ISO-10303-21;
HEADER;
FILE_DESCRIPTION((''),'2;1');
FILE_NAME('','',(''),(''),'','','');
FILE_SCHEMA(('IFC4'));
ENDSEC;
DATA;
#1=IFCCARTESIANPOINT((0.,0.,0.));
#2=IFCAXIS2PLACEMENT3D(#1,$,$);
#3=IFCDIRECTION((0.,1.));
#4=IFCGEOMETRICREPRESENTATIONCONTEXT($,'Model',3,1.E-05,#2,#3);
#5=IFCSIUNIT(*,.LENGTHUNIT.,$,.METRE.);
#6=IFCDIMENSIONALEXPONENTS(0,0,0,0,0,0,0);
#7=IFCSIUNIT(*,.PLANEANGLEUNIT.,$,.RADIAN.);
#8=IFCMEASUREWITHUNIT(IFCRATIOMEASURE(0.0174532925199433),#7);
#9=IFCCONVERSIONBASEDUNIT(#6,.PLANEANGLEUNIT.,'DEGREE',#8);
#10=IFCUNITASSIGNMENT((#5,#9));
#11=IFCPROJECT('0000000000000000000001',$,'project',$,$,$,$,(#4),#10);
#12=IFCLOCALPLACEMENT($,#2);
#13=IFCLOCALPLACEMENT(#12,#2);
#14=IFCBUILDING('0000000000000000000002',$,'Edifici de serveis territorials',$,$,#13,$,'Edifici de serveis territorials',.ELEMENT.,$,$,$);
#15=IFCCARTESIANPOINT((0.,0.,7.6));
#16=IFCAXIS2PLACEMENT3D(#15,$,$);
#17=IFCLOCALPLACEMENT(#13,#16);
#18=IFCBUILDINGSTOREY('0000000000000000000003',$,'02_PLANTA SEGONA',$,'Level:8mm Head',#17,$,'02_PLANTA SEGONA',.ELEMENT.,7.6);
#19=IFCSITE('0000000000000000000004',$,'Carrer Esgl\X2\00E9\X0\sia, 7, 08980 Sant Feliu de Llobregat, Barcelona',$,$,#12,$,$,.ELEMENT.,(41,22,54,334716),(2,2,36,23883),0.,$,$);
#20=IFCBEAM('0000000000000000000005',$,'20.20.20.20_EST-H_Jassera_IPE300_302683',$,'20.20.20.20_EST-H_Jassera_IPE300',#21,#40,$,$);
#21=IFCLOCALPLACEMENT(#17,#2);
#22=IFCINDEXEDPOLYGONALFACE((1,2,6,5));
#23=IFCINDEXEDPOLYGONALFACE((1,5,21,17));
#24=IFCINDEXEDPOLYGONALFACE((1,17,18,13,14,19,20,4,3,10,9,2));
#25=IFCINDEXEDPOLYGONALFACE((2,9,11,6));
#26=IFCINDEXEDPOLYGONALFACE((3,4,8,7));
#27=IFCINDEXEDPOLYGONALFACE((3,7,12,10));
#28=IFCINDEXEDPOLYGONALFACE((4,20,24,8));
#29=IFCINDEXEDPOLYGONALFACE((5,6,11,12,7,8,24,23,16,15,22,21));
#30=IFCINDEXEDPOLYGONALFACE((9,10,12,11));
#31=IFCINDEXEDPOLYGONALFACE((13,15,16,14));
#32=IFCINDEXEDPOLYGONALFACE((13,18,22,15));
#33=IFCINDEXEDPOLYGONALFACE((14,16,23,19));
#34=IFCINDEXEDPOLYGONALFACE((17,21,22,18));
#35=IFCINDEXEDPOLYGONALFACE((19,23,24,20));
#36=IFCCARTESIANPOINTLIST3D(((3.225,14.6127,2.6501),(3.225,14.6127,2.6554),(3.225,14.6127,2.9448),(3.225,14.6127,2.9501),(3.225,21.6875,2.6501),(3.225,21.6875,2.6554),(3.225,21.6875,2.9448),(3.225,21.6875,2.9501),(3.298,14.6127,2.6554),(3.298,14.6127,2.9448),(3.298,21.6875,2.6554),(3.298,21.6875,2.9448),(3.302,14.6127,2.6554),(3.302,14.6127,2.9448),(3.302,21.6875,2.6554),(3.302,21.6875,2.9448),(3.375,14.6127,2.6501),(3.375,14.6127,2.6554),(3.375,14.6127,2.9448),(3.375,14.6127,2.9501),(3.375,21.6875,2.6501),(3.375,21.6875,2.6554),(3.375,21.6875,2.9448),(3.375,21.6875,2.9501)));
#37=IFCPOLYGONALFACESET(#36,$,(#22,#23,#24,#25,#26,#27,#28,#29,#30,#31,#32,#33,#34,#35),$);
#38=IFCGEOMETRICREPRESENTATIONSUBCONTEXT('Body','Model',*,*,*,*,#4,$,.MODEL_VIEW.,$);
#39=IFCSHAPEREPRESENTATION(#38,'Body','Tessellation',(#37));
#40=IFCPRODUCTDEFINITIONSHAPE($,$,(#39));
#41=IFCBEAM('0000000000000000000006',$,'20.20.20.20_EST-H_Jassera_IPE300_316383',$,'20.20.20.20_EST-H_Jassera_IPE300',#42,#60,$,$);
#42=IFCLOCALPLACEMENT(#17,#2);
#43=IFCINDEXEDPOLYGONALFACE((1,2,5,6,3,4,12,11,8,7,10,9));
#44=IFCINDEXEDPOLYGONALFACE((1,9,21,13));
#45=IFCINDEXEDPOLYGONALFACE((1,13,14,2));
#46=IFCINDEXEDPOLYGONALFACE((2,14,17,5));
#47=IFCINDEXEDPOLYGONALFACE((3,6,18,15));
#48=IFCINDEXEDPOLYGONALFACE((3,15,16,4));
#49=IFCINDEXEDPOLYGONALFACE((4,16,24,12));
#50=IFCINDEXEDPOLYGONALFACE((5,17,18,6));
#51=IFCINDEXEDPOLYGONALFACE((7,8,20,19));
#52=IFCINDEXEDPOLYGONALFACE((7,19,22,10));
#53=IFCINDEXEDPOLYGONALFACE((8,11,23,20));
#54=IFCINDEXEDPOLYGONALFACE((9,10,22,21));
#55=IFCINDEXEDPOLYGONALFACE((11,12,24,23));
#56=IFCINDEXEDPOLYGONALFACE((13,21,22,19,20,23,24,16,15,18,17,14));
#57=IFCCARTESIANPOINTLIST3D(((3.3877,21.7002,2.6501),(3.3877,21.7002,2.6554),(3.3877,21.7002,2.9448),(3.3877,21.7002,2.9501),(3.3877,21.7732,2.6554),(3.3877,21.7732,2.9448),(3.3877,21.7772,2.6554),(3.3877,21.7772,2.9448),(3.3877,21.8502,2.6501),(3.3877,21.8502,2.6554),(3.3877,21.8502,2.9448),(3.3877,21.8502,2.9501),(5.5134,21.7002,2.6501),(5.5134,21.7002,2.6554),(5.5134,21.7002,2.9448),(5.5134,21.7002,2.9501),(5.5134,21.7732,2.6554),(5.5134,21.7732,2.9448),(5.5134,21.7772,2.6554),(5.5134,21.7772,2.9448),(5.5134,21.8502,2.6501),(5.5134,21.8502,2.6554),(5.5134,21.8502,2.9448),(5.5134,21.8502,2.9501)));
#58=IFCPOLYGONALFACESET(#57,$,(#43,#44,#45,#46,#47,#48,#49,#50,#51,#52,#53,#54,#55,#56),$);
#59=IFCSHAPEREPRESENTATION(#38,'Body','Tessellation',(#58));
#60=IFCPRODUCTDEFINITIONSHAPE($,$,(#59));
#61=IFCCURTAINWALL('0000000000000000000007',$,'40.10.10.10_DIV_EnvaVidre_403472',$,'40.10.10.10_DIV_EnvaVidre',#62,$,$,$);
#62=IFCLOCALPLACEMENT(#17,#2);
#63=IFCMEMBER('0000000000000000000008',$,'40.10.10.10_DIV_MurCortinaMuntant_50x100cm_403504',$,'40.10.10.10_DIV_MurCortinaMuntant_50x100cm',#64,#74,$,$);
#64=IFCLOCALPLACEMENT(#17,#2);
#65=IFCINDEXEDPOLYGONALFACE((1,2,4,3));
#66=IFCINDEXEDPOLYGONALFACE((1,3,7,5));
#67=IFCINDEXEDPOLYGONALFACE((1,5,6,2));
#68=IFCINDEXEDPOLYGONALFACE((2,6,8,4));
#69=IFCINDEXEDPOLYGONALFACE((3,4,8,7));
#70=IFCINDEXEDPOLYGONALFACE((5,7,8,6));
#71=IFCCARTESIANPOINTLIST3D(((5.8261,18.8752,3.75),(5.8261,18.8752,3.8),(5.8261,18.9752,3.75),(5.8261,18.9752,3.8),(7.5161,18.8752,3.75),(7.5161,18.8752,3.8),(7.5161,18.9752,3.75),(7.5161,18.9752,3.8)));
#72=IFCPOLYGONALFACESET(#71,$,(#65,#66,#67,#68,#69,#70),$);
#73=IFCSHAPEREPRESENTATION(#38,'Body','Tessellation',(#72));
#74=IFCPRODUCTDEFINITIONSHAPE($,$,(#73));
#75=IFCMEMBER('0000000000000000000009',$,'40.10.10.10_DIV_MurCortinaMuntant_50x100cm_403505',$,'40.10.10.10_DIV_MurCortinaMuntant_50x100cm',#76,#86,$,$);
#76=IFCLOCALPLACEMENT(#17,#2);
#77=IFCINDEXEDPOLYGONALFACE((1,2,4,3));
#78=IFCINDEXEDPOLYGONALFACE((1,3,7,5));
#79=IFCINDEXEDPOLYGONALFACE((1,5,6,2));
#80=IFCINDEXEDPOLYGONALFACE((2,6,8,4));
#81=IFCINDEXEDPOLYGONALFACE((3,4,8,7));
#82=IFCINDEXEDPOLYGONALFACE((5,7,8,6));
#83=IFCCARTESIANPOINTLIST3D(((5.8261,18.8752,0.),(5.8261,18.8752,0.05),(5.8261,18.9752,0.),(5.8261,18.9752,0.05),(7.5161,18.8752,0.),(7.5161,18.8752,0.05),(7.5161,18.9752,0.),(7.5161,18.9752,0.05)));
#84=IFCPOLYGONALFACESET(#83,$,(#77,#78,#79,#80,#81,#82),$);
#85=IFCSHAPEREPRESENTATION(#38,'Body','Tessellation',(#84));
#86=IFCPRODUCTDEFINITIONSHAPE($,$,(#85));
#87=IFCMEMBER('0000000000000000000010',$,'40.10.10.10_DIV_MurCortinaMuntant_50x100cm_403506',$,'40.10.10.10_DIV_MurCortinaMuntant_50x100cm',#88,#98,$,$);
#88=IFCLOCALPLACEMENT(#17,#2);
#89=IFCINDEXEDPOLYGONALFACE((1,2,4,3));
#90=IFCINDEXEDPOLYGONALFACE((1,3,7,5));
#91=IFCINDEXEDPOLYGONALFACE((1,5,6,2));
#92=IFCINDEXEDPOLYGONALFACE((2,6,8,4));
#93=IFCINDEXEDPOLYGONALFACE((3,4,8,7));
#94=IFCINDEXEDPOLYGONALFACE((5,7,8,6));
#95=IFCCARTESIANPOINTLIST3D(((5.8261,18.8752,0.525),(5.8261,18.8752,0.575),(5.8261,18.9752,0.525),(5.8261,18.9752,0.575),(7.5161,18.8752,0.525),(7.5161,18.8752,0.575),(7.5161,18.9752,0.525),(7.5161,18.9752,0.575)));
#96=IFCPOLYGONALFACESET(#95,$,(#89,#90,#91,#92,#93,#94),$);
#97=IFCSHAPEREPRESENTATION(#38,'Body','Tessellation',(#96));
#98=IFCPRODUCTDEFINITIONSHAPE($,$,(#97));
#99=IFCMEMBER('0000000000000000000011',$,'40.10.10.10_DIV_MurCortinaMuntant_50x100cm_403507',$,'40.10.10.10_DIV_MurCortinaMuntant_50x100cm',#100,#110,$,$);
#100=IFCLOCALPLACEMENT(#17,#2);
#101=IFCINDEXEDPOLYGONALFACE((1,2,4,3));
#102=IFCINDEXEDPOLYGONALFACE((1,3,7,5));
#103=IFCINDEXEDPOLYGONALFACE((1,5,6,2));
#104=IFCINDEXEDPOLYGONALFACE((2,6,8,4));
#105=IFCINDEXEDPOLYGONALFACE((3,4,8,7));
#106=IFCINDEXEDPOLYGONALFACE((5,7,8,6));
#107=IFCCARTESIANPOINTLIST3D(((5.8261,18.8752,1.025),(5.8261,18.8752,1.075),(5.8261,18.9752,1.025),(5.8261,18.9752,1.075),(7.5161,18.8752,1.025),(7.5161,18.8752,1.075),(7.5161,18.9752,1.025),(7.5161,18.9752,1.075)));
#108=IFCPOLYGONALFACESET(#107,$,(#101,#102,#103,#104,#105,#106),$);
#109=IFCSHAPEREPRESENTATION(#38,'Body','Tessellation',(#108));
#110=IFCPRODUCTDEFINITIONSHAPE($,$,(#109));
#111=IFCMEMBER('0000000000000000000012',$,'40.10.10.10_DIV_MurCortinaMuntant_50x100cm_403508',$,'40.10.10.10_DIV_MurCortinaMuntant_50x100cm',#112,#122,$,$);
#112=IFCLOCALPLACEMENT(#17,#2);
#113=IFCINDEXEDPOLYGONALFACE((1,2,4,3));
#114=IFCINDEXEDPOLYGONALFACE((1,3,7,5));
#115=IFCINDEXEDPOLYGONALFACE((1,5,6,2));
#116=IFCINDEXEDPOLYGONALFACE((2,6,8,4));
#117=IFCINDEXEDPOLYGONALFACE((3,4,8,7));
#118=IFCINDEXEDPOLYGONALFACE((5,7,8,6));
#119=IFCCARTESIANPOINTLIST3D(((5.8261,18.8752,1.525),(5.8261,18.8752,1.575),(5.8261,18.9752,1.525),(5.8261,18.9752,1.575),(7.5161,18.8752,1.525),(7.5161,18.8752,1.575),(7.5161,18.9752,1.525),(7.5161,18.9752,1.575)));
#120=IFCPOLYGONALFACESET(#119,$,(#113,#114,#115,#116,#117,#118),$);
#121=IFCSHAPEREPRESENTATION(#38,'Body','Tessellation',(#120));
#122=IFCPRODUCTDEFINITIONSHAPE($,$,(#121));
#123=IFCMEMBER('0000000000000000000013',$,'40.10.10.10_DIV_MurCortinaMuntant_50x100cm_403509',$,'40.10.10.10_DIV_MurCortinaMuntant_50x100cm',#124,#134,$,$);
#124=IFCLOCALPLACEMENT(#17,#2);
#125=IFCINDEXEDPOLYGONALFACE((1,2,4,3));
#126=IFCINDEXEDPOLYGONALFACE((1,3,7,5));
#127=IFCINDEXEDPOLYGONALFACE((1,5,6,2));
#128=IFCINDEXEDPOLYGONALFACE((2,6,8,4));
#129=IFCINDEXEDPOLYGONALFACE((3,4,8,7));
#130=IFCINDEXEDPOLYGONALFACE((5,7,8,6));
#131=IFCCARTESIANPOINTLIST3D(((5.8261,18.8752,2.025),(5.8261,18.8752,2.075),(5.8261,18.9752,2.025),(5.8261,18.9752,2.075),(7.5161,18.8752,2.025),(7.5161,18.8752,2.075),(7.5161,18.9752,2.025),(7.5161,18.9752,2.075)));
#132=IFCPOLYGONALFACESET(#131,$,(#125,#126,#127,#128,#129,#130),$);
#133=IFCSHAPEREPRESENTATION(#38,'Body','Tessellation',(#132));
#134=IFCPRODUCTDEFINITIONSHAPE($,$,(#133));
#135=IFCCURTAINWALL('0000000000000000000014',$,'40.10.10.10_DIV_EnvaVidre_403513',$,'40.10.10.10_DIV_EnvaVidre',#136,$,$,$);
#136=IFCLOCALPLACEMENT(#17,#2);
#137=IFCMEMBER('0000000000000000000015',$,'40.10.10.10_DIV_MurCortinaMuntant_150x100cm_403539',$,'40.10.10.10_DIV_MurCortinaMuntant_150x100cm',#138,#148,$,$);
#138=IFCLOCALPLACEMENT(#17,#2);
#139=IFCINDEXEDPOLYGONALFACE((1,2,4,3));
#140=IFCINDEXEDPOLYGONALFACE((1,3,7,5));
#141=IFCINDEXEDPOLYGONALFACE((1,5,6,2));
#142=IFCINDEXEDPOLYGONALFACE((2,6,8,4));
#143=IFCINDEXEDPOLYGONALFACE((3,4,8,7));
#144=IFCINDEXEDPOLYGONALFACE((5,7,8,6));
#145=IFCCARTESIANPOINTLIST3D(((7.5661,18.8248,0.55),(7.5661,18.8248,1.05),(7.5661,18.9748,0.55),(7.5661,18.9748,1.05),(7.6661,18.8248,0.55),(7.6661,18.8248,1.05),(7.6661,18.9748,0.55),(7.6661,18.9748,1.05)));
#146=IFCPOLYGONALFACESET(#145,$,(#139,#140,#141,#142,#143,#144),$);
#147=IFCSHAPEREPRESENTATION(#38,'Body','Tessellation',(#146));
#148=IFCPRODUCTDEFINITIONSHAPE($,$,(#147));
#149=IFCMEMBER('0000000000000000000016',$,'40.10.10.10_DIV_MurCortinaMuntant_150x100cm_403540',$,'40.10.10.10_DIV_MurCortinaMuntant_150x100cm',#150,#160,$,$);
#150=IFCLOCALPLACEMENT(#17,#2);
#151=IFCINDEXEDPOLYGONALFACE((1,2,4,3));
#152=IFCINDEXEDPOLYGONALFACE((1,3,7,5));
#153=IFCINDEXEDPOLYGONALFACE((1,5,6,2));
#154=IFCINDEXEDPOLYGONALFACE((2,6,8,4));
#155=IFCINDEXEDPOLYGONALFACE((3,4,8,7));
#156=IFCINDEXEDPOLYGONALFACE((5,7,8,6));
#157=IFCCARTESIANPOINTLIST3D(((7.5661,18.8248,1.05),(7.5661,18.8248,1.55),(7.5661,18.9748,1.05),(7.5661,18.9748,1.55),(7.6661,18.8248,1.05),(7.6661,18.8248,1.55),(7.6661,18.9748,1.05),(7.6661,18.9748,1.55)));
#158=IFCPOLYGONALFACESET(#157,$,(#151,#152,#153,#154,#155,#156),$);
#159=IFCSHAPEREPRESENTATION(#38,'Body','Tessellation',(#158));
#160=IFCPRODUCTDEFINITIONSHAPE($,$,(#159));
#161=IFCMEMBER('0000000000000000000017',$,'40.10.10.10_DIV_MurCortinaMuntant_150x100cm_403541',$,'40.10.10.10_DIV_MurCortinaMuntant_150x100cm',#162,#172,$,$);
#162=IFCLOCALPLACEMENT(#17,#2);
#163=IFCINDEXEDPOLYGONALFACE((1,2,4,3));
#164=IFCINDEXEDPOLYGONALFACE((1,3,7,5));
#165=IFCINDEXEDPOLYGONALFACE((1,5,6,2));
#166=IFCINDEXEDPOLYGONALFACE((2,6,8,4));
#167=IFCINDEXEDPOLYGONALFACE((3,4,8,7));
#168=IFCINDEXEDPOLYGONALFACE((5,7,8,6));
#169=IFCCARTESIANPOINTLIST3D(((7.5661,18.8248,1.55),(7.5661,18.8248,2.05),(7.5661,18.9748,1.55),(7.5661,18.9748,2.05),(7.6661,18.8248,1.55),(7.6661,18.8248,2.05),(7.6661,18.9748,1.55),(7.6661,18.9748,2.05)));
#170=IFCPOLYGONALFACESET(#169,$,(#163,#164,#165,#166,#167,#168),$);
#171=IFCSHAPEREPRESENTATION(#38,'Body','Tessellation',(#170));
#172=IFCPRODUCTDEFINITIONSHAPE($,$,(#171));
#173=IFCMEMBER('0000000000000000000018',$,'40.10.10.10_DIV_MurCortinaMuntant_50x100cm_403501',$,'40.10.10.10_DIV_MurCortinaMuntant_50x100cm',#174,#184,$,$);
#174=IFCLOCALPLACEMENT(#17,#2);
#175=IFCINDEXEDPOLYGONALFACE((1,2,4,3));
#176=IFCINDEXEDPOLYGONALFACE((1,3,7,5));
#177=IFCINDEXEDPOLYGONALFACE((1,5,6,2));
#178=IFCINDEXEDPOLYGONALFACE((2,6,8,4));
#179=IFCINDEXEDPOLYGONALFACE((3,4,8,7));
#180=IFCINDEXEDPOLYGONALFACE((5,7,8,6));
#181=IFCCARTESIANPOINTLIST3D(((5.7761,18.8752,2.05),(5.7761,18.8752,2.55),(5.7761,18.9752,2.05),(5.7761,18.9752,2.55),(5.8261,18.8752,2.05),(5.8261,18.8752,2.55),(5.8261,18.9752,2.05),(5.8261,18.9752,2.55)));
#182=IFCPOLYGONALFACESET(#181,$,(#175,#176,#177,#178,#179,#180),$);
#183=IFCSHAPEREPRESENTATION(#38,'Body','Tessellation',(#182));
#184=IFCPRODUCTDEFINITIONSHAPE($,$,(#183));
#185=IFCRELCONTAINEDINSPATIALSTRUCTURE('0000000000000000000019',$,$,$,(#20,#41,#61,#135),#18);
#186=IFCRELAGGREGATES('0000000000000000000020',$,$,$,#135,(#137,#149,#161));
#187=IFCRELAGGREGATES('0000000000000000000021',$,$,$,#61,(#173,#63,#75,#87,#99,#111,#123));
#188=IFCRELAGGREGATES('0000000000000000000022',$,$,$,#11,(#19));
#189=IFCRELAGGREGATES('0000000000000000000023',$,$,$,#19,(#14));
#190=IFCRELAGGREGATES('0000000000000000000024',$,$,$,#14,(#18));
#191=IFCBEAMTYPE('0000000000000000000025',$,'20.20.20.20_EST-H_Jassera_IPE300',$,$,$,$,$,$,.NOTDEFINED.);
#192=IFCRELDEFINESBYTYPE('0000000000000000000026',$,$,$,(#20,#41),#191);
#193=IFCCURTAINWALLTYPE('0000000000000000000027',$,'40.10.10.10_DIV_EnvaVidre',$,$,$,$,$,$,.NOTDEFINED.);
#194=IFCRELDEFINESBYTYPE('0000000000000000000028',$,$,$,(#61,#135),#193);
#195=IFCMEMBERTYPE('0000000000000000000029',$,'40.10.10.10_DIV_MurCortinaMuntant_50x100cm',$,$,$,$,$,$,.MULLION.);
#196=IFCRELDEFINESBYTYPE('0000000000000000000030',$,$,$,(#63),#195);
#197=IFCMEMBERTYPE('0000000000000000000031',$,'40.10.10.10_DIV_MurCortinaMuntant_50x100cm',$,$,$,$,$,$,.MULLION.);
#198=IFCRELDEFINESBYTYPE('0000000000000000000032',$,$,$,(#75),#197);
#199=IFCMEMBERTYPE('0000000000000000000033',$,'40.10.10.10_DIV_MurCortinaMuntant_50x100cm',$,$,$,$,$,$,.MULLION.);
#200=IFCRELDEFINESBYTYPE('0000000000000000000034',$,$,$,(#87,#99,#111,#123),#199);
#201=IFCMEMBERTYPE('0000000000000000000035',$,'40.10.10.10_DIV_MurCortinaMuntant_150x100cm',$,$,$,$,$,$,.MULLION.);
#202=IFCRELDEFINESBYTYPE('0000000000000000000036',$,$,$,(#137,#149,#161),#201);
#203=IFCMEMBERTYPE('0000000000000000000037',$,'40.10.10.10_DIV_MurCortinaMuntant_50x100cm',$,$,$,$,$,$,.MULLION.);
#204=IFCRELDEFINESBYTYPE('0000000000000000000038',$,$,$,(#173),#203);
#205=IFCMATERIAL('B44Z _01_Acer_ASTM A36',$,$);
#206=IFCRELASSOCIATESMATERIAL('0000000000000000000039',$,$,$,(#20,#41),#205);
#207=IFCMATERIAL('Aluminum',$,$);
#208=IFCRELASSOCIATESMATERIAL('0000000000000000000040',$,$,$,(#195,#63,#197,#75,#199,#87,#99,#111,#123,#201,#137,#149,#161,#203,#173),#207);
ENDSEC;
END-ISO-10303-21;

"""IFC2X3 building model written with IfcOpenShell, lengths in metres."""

from ifc_helpers import new_model, entity, si_unit, converted_unit, direction, frame, frame_2d, origin, origin_2d_with_axis, place, context, subcontext, project, spatial, rectangle, i_section, extrude, source, transform, mapped, material, type_object, type_shapes, element, aggregate, save


model = new_model("IFC2X3")

# Units and contexts
model_context = context("Model", 3, precision=1e-05, world=origin(), true_north=direction((0.0, 1.0)))
body_context = subcontext(model_context, "Body", "Model", "MODEL_VIEW")
ifc_project = project(units=[si_unit("LENGTHUNIT", "METRE"), converted_unit("PLANEANGLEUNIT", "DEGREE", entity("IfcRatioMeasure", 0.0174532925199433), si_unit("PLANEANGLEUNIT", "RADIAN"), dimensions=[0, 0, 0, 0, 0, 0, 0])], contexts=[model_context])

# Site, building, storey
site_placement = place(None, origin())
site = spatial("IfcSite", under=ifc_project, at=site_placement, Name="Carrer Església, 7, 08980 Sant Feliu de Llobregat, Barcelona", CompositionType="ELEMENT", RefLatitude=(41, 22, 54, 334716), RefLongitude=(2, 2, 36, 23883), RefElevation=0.0)
building_placement = place(site_placement, origin())
building = spatial("IfcBuilding", under=site, at=building_placement, Name="Edifici de serveis territorials", LongName="Edifici de serveis territorials", CompositionType="ELEMENT")
storey_placement = place(building_placement, frame((0.0, 0.0, 7.6)))
storey = spatial("IfcBuildingStorey", under=building, at=storey_placement, Name="02_PLANTA SEGONA", ObjectType="Level:8mm Head", LongName="02_PLANTA SEGONA", CompositionType="ELEMENT", Elevation=7.6)

# Beams
ifc_material_1 = material(Name="B44Z _01_Acer_ASTM A36")
beam_type = type_object("IfcBeamType", Name="20.20.20.20_EST-H_Jassera_IPE300", PredefinedType="NOTDEFINED")
beam_1_placement = place(storey_placement, frame((3.3, 21.7752, 0.0), z_axis=(0.0, 0.0, 1.0), x_axis=(0.0, -1.0, 0.0)))
element("IfcBeam", 1, at=beam_1_placement, inside=storey, type_object=beam_type, material=ifc_material_1, Name="20.20.20.20_EST-H_Jassera_IPE300_302683", ObjectType="20.20.20.20_EST-H_Jassera_IPE300", context=body_context, shape_type="SweptSolid", body=[
    extrude(i_section(OverallWidth=0.15, OverallDepth=0.3, WebThickness=0.0041, FlangeThickness=0.0053, at=frame_2d((0.0, 0.0), x_axis=(0.0, 1.0))), frame((0.0877, 0.0, 2.8001), z_axis=(1.0, 0.0, 0.0), x_axis=(0.0, 0.0, -1.0)), (0.0, 0.0, 1.0), 7.0748),
])
beam_2_placement = place(storey_placement, frame((3.3, 21.7752, 0.0)))
element("IfcBeam", 2, at=beam_2_placement, inside=storey, type_object=beam_type, material=ifc_material_1, Name="20.20.20.20_EST-H_Jassera_IPE300_316383", ObjectType="20.20.20.20_EST-H_Jassera_IPE300", context=body_context, shape_type="SweptSolid", body=[
    extrude(i_section(OverallWidth=0.15, OverallDepth=0.3, WebThickness=0.0041, FlangeThickness=0.0053, at=frame_2d((0.0, 0.0), x_axis=(0.0, 1.0))), frame((0.0877, 0.0, 2.8001), z_axis=(1.0, 0.0, 0.0), x_axis=(0.0, 0.0, -1.0)), (0.0, 0.0, 1.0), 2.1257),
])

# Curtain walls, members
curtain_wall_type = type_object("IfcCurtainWallType", Name="40.10.10.10_DIV_EnvaVidre", PredefinedType="NOTDEFINED")
curtain_wall_1_placement = place(storey_placement, frame((0.0, 0.0, -7.6)))
curtain_wall_1 = element("IfcCurtainWall", 3, at=curtain_wall_1_placement, inside=storey, type_object=curtain_wall_type, Name="40.10.10.10_DIV_EnvaVidre_403472", ObjectType="40.10.10.10_DIV_EnvaVidre")
ifc_material_2 = material(Name="Aluminum")
member_type_1 = type_object("IfcMemberType", Name="40.10.10.10_DIV_MurCortinaMuntant_50x100cm", PredefinedType="MULLION", material=ifc_material_2)
shared_shape_1 = source(origin(), body_context, "Body", "SweptSolid", [
    extrude(rectangle(XDim=0.1, YDim=0.05, at=origin_2d_with_axis()), frame((-0.025, 0.0, -1.69), z_axis=(0.0, 0.0, 1.0), x_axis=(0.0, -1.0, 0.0)), (0.0, 0.0, 1.0), 1.69),
])
type_shapes(member_type_1, [shared_shape_1])
member_1_placement = place(storey_placement, frame((7.5161, 18.9252, 3.8), z_axis=(1.0, 0.0, 0.0), x_axis=(0.0, 0.0, 1.0)))
member_1 = element("IfcMember", 4, at=member_1_placement, type_object=member_type_1, material=ifc_material_2, Name="40.10.10.10_DIV_MurCortinaMuntant_50x100cm_403504", ObjectType="40.10.10.10_DIV_MurCortinaMuntant_50x100cm", context=body_context, shape_type="MappedRepresentation", body=[
    mapped(shared_shape_1, transform((0.0, 0.0, 0.0), scale=1.0)),
])
member_type_2 = type_object("IfcMemberType", Name="40.10.10.10_DIV_MurCortinaMuntant_50x100cm", PredefinedType="MULLION", material=ifc_material_2)
shared_shape_2 = source(origin(), body_context, "Body", "SweptSolid", [
    extrude(rectangle(XDim=0.1, YDim=0.05, at=origin_2d_with_axis()), frame((-0.025, 0.0, -1.69), z_axis=(0.0, 0.0, 1.0), x_axis=(0.0, -1.0, 0.0)), (0.0, 0.0, 1.0), 1.69),
])
type_shapes(member_type_2, [shared_shape_2])
member_2_placement = place(storey_placement, frame((5.8261, 18.9252, 0.0), z_axis=(-1.0, 0.0, 0.0), x_axis=(0.0, 0.0, -1.0)))
member_2 = element("IfcMember", 5, at=member_2_placement, type_object=member_type_2, material=ifc_material_2, Name="40.10.10.10_DIV_MurCortinaMuntant_50x100cm_403505", ObjectType="40.10.10.10_DIV_MurCortinaMuntant_50x100cm", context=body_context, shape_type="MappedRepresentation", body=[
    mapped(shared_shape_2, transform((0.0, 0.0, 0.0), scale=1.0)),
])
member_type_3 = type_object("IfcMemberType", Name="40.10.10.10_DIV_MurCortinaMuntant_50x100cm", PredefinedType="MULLION", material=ifc_material_2)
shared_shape_3 = source(origin(), body_context, "Body", "SweptSolid", [
    extrude(rectangle(XDim=0.1, YDim=0.05, at=origin_2d_with_axis()), frame((0.0, 0.0, -1.69), z_axis=(0.0, 0.0, 1.0), x_axis=(0.0, -1.0, 0.0)), (0.0, 0.0, 1.0), 1.69),
])
type_shapes(member_type_3, [shared_shape_3])
member_3_placement = place(storey_placement, frame((7.5161, 18.9252, 0.55), z_axis=(1.0, 0.0, 0.0), x_axis=(0.0, 0.0, 1.0)))
member_3 = element("IfcMember", 6, at=member_3_placement, type_object=member_type_3, material=ifc_material_2, Name="40.10.10.10_DIV_MurCortinaMuntant_50x100cm_403506", ObjectType="40.10.10.10_DIV_MurCortinaMuntant_50x100cm", context=body_context, shape_type="MappedRepresentation", body=[
    mapped(shared_shape_3, transform((0.0, 0.0, 0.0), scale=1.0)),
])
member_4_placement = place(storey_placement, frame((7.5161, 18.9252, 1.05), z_axis=(1.0, 0.0, 0.0), x_axis=(0.0, 0.0, 1.0)))
member_4 = element("IfcMember", 7, at=member_4_placement, type_object=member_type_3, material=ifc_material_2, Name="40.10.10.10_DIV_MurCortinaMuntant_50x100cm_403507", ObjectType="40.10.10.10_DIV_MurCortinaMuntant_50x100cm", context=body_context, shape_type="MappedRepresentation", body=[
    mapped(shared_shape_3, transform((0.0, 0.0, 0.0), scale=1.0)),
])
member_5_placement = place(storey_placement, frame((7.5161, 18.9252, 1.55), z_axis=(1.0, 0.0, 0.0), x_axis=(0.0, 0.0, 1.0)))
member_5 = element("IfcMember", 8, at=member_5_placement, type_object=member_type_3, material=ifc_material_2, Name="40.10.10.10_DIV_MurCortinaMuntant_50x100cm_403508", ObjectType="40.10.10.10_DIV_MurCortinaMuntant_50x100cm", context=body_context, shape_type="MappedRepresentation", body=[
    mapped(shared_shape_3, transform((0.0, 0.0, 0.0), scale=1.0)),
])
member_6_placement = place(storey_placement, frame((7.5161, 18.9252, 2.05), z_axis=(1.0, 0.0, 0.0), x_axis=(0.0, 0.0, 1.0)))
member_6 = element("IfcMember", 9, at=member_6_placement, type_object=member_type_3, material=ifc_material_2, Name="40.10.10.10_DIV_MurCortinaMuntant_50x100cm_403509", ObjectType="40.10.10.10_DIV_MurCortinaMuntant_50x100cm", context=body_context, shape_type="MappedRepresentation", body=[
    mapped(shared_shape_3, transform((0.0, 0.0, 0.0), scale=1.0)),
])
curtain_wall_2_placement = place(storey_placement, frame((0.0, 0.0, -7.6)))
curtain_wall_2 = element("IfcCurtainWall", 10, at=curtain_wall_2_placement, inside=storey, type_object=curtain_wall_type, Name="40.10.10.10_DIV_EnvaVidre_403513", ObjectType="40.10.10.10_DIV_EnvaVidre")
member_type_4 = type_object("IfcMemberType", Name="40.10.10.10_DIV_MurCortinaMuntant_150x100cm", PredefinedType="MULLION", material=ifc_material_2)
shared_shape_4 = source(origin(), body_context, "Body", "SweptSolid", [
    extrude(rectangle(XDim=0.1, YDim=0.15, at=origin_2d_with_axis()), frame((-0.075, 0.0, -0.5), z_axis=(0.0, 0.0, 1.0), x_axis=(0.0, -1.0, 0.0)), (0.0, 0.0, 1.0), 0.5),
])
type_shapes(member_type_4, [shared_shape_4])
member_7_placement = place(storey_placement, frame((7.6161, 18.9748, 1.05), z_axis=(0.0, 0.0, 1.0), x_axis=(0.0, 1.0, 0.0)))
member_7 = element("IfcMember", 11, at=member_7_placement, type_object=member_type_4, material=ifc_material_2, Name="40.10.10.10_DIV_MurCortinaMuntant_150x100cm_403539", ObjectType="40.10.10.10_DIV_MurCortinaMuntant_150x100cm", context=body_context, shape_type="MappedRepresentation", body=[
    mapped(shared_shape_4, transform((0.0, 0.0, 0.0), scale=1.0)),
])
member_8_placement = place(storey_placement, frame((7.6161, 18.9748, 1.55), z_axis=(0.0, 0.0, 1.0), x_axis=(0.0, 1.0, 0.0)))
member_8 = element("IfcMember", 12, at=member_8_placement, type_object=member_type_4, material=ifc_material_2, Name="40.10.10.10_DIV_MurCortinaMuntant_150x100cm_403540", ObjectType="40.10.10.10_DIV_MurCortinaMuntant_150x100cm", context=body_context, shape_type="MappedRepresentation", body=[
    mapped(shared_shape_4, transform((0.0, 0.0, 0.0), scale=1.0)),
])
member_9_placement = place(storey_placement, frame((7.6161, 18.9748, 2.05), z_axis=(0.0, 0.0, 1.0), x_axis=(0.0, 1.0, 0.0)))
member_9 = element("IfcMember", 13, at=member_9_placement, type_object=member_type_4, material=ifc_material_2, Name="40.10.10.10_DIV_MurCortinaMuntant_150x100cm_403541", ObjectType="40.10.10.10_DIV_MurCortinaMuntant_150x100cm", context=body_context, shape_type="MappedRepresentation", body=[
    mapped(shared_shape_4, transform((0.0, 0.0, 0.0), scale=1.0)),
])

# Member
member_type_5 = type_object("IfcMemberType", Name="40.10.10.10_DIV_MurCortinaMuntant_50x100cm", PredefinedType="MULLION", material=ifc_material_2)
shared_shape_5 = source(origin(), body_context, "Body", "SweptSolid", [
    extrude(rectangle(XDim=0.1, YDim=0.05, at=origin_2d_with_axis()), frame((-0.025, 0.0, -0.5), z_axis=(0.0, 0.0, 1.0), x_axis=(0.0, -1.0, 0.0)), (0.0, 0.0, 1.0), 0.5),
])
type_shapes(member_type_5, [shared_shape_5])
member_10_placement = place(storey_placement, frame((5.7761, 18.9252, 2.55), z_axis=(0.0, 0.0, 1.0), x_axis=(-1.0, 0.0, 0.0)))
member_10 = element("IfcMember", 14, at=member_10_placement, type_object=member_type_5, material=ifc_material_2, Name="40.10.10.10_DIV_MurCortinaMuntant_50x100cm_403501", ObjectType="40.10.10.10_DIV_MurCortinaMuntant_50x100cm", context=body_context, shape_type="MappedRepresentation", body=[
    mapped(shared_shape_5, transform((0.0, 0.0, 0.0), scale=1.0)),
])
aggregate(curtain_wall_2, [member_7, member_8, member_9])

aggregate(curtain_wall_1, [member_10, member_1, member_2, member_3, member_4, member_5, member_6])

save(model, "model.ifc")
